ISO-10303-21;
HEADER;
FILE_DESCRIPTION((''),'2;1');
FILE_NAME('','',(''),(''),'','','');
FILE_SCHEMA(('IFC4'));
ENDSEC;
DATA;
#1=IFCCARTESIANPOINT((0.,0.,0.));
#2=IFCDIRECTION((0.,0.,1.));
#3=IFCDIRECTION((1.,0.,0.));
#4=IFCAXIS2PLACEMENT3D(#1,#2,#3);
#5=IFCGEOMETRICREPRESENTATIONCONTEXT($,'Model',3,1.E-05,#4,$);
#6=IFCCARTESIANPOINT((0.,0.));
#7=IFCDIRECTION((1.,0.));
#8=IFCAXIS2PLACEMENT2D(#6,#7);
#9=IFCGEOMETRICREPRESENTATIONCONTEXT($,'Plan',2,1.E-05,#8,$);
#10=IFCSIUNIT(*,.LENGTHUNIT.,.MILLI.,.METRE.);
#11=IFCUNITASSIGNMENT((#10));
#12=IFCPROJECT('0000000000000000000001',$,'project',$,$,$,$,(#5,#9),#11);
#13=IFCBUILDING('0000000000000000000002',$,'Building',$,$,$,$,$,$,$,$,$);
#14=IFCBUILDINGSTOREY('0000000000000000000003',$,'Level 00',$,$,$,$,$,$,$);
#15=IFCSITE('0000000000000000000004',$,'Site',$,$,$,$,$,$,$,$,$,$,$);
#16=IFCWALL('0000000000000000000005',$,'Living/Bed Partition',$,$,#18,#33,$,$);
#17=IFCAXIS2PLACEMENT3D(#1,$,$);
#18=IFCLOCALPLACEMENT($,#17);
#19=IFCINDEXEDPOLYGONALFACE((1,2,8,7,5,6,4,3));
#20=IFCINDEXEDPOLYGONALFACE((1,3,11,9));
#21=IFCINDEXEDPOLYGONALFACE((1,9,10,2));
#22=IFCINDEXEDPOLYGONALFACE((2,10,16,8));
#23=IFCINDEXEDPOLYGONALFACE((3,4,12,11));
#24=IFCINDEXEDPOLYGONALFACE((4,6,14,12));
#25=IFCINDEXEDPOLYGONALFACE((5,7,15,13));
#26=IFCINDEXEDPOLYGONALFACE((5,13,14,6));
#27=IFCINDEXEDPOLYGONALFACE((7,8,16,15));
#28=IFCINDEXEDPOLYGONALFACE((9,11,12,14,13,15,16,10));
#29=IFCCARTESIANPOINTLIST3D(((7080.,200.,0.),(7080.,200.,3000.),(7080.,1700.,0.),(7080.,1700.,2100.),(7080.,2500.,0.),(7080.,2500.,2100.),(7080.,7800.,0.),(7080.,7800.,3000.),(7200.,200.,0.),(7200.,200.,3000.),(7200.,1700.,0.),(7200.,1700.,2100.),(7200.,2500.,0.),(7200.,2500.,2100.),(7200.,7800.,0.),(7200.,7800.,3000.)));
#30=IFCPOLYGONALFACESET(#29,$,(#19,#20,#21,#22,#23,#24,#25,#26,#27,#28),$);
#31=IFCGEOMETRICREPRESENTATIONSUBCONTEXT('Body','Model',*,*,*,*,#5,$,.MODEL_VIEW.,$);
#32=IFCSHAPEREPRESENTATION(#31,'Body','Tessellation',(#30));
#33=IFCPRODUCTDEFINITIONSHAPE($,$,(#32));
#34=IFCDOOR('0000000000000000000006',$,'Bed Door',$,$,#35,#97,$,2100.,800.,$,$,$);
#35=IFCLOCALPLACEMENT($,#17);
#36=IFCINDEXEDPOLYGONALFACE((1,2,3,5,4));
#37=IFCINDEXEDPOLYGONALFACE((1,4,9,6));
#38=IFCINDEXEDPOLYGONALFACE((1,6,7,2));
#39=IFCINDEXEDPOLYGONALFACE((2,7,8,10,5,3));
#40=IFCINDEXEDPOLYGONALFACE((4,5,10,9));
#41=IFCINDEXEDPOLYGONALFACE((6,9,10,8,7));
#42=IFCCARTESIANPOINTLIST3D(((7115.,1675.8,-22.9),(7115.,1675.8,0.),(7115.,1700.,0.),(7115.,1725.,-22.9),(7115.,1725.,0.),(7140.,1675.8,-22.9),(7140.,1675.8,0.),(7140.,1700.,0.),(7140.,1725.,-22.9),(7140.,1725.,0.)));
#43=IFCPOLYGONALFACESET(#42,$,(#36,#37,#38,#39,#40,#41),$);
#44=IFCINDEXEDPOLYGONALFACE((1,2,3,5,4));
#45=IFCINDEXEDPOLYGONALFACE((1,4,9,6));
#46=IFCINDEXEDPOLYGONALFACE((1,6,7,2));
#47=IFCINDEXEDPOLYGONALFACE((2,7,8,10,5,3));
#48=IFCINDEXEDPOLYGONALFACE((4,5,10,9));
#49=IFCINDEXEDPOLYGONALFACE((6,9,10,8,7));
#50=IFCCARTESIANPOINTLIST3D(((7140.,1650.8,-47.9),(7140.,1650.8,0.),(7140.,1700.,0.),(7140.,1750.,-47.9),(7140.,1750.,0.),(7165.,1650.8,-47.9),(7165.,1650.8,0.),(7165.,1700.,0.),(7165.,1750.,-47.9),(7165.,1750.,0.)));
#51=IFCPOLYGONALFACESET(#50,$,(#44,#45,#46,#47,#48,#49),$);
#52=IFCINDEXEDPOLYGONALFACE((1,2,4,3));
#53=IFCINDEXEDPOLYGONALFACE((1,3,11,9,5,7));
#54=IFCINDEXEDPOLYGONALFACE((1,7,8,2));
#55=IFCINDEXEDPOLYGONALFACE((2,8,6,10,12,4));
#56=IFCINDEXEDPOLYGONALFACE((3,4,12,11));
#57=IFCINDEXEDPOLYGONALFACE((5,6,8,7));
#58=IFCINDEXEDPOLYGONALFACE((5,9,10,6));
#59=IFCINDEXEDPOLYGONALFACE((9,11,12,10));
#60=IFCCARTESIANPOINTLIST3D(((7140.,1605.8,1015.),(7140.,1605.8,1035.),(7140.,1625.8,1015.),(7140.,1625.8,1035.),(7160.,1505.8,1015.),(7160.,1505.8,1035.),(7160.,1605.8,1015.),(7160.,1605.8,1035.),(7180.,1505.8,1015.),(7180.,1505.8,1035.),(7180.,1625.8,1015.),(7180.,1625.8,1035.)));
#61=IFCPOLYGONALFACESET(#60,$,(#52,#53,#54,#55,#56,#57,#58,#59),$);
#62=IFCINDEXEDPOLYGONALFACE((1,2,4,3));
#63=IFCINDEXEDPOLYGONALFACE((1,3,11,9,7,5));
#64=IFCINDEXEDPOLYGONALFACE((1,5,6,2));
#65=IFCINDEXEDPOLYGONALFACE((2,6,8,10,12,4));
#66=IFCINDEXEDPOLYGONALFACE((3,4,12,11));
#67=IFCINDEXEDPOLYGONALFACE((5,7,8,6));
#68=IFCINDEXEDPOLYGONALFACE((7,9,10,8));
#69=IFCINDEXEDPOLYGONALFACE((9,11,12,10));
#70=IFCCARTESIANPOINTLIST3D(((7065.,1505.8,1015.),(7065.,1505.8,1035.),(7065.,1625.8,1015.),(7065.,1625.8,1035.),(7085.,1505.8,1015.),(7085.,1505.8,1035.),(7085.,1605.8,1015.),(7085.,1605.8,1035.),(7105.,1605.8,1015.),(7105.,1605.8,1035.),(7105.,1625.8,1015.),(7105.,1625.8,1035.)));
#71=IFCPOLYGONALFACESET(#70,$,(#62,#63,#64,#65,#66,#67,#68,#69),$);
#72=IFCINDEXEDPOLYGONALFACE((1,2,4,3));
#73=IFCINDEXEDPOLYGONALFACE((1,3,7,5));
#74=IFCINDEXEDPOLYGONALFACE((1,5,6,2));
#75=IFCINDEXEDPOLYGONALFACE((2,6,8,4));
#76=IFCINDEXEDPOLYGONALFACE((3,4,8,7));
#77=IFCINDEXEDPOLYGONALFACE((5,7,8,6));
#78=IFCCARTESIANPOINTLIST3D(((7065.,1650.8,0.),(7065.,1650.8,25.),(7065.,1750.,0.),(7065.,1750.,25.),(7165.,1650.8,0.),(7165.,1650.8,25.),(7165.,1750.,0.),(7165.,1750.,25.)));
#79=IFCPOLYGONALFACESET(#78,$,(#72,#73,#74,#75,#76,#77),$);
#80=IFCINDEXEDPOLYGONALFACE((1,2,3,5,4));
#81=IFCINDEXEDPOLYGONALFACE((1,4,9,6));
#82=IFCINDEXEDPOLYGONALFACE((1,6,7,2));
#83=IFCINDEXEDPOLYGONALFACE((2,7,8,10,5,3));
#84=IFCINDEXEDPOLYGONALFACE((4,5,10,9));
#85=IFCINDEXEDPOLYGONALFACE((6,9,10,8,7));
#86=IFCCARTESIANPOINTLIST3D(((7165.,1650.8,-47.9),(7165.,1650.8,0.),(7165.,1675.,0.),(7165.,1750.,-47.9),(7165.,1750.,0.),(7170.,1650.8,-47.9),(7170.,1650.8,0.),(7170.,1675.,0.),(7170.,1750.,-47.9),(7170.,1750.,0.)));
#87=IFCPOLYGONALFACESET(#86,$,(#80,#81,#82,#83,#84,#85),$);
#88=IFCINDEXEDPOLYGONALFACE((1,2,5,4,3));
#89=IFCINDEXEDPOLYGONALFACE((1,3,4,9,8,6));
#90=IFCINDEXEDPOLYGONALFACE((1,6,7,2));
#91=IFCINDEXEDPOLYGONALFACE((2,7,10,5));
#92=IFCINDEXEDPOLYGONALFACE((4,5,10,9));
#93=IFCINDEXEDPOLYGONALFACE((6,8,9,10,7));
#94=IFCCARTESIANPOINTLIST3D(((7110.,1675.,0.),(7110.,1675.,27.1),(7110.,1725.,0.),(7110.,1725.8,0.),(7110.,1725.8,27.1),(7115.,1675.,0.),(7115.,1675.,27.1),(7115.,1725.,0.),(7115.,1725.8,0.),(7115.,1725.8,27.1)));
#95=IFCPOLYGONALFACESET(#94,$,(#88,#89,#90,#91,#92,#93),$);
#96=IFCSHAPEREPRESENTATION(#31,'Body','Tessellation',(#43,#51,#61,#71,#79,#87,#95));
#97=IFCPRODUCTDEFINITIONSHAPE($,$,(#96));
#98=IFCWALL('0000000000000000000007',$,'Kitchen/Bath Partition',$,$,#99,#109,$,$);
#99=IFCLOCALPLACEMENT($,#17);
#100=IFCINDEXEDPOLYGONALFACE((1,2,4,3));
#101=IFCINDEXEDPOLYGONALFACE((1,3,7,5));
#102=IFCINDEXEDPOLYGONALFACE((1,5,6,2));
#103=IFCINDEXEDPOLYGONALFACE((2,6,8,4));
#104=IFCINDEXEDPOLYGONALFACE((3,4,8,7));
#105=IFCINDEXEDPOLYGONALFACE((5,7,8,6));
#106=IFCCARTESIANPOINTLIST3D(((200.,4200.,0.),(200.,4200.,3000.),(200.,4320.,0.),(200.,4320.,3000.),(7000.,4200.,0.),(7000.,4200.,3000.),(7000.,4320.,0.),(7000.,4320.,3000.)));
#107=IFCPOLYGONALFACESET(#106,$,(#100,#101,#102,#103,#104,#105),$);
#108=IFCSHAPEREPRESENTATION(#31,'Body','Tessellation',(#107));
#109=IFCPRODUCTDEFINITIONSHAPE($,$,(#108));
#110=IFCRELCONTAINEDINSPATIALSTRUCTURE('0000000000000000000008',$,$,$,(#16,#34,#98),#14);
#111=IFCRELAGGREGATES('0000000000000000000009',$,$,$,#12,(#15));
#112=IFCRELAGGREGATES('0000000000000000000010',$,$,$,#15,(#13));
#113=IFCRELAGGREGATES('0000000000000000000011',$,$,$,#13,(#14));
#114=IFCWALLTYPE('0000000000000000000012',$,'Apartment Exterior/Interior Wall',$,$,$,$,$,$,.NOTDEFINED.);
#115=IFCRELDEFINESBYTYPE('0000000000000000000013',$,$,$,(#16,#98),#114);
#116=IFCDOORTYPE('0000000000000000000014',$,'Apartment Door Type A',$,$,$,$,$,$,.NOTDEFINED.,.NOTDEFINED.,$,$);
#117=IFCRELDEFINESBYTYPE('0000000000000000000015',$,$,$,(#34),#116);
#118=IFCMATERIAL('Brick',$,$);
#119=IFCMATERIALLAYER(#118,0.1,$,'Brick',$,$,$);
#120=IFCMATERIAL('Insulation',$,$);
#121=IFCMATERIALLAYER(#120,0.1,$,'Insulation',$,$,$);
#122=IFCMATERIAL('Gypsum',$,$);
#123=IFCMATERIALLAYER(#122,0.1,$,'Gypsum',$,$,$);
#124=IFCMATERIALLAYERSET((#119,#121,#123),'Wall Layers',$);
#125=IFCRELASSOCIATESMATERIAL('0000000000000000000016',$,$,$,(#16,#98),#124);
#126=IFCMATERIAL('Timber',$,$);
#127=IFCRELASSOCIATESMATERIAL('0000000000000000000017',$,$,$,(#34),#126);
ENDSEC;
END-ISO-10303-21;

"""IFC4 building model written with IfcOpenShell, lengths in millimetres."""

from ifc_helpers import new_model, si_unit, frame, origin_with_axes, origin_2d_with_axis, place, context, subcontext, project, spatial, line, indexed_curve, outline, extrude, material, layer, layer_set, layer_usage, type_object, element, fill, save


model = new_model("IFC4")

# Units and contexts
model_context = context("Model", 3, precision=1e-05, world=origin_with_axes())
plan_context = context("Plan", 2, precision=1e-05, world=origin_2d_with_axis())
body_context = subcontext(model_context, "Body", "Model", "MODEL_VIEW")
ifc_project = project(units=[si_unit("LENGTHUNIT", "METRE", prefix="MILLI")], contexts=[model_context, plan_context])

# Site, building, storey
site = spatial("IfcSite", under=ifc_project, Name="Site")
building = spatial("IfcBuilding", under=site, Name="Building")
storey = spatial("IfcBuildingStorey", under=building, Name="Level 00")

# Shared definitions
ifc_material_1 = material(Name="Brick")
ifc_layer_1 = layer(ifc_material_1, 0.1, Name="Brick")
ifc_material_2 = material(Name="Insulation")
ifc_layer_2 = layer(ifc_material_2, 0.1, Name="Insulation")
ifc_material_3 = material(Name="Gypsum")
ifc_layer_3 = layer(ifc_material_3, 0.1, Name="Gypsum")
ifc_layer_set = layer_set([ifc_layer_1, ifc_layer_2, ifc_layer_3], Name="Wall Layers")
ifc_layer_usage = layer_usage(ifc_layer_set, "AXIS2", "POSITIVE", 0.0)
wall_type = type_object("IfcWallType", Name="Apartment Exterior/Interior Wall", PredefinedType="NOTDEFINED")
ifc_material_4 = material(Name="Timber")
door_type = type_object("IfcDoorType", Name="Apartment Door Type A", OperationType="NOTDEFINED", PredefinedType="NOTDEFINED")

# Wall, opening, door
wall_1_placement = place(None, frame((7200.0, 200.0, 0.0), z_axis=(0.0, 0.0, 1.0), x_axis=(0.0, 1.0, 0.0)))
wall_1 = element("IfcWall", 1, at=wall_1_placement, inside=storey, type_object=wall_type, material=ifc_layer_usage, Name="Living/Bed Partition", context=body_context, shape_type="SweptSolid", body=[
    extrude(outline(indexed_curve([(0.0, 0.0), (0.0, 120.0), (7600.0, 120.0), (7600.0, 0.0), (0.0, 0.0)], self_intersect=False)), origin_with_axes(), (0.0, 0.0, 1.0), 3000.0),
])
opening_1_placement = place(wall_1_placement, frame((1500.0, -12.0, 0.0), z_axis=(0.0, 0.0, 1.0), x_axis=(1.0, 0.0, 0.0)))
opening_1 = element("IfcOpeningElement", 2, at=opening_1_placement, cuts=wall_1, context=body_context, shape_type="SweptSolid", body=[
    extrude(outline(indexed_curve([(0.0, 0.0), (0.0, 144.0), (800.0, 144.0), (800.0, 0.0), (0.0, 0.0)], self_intersect=False)), origin_with_axes(), (0.0, 0.0, 1.0), 2100.0),
])
door_1_placement = place(opening_1_placement, frame((0.0, 47.0, 0.0), z_axis=(0.0, 0.0, 1.0), x_axis=(1.0, 0.0, 0.0)))
door_1 = element("IfcDoor", 3, at=door_1_placement, inside=storey, type_object=door_type, material=ifc_material_4, Name="Bed Door", OverallHeight=2100.0, OverallWidth=800.0, context=body_context, shape_type="SweptSolid", body=[
    extrude(outline(indexed_curve([(0.0, 0.0), (0.0, 2.1), (0.8, 2.1), (0.8, 0.0), (-24.2, 0.0), (-24.2, -22.9), (25.0, -22.9), (25.0, 0.0)], segments=[line(1, 2, 3, 4, 5, 6, 7, 8, 1)])), frame((0.0, 25.0, 0.0), z_axis=(0.0, -1.0, 0.0), x_axis=(1.0, 0.0, 0.0)), (0.0, 0.0, -1.0), 25.0),
    extrude(outline(indexed_curve([(0.0, 0.0), (0.0, 2.1), (0.8, 2.1), (0.8, 0.0), (-49.2, 0.0), (-49.2, -47.9), (50.0, -47.9), (50.0, 0.0)], segments=[line(1, 2, 3, 4, 5, 6, 7, 8, 1)])), frame((0.0, 0.0, 0.0), z_axis=(0.0, -1.0, 0.0), x_axis=(1.0, 0.0, 0.0)), (0.0, 0.0, -1.0), 25.0),
    extrude(outline(indexed_curve([(0.0, 0.0), (-49.2, 0.0), (-49.2, 35.0), (0.0, 35.0)], segments=[line(1, 2, 3, 4, 1)])), frame((25.0, 25.0, 25.0), z_axis=(0.0, 0.0, 1.0), x_axis=(1.0, 0.0, 0.0)), (0.0, 0.0, 1.0), -47.9),
    extrude(outline(indexed_curve([(0.0, 0.0), (0.0, -40.0), (-120.0, -40.0), (-120.0, -20.0), (-20.0, -20.0), (-20.0, 0.0)], segments=[line(1, 2, 3, 4, 5, 6, 1)])), frame((-74.2, 25.0, 1015.0), z_axis=(0.0, 0.0, 1.0), x_axis=(1.0, 0.0, 0.0)), (0.0, 0.0, 1.0), 20.0),
    extrude(outline(indexed_curve([(0.0, 0.0), (0.0, 40.0), (-120.0, 40.0), (-120.0, 20.0), (-20.0, 20.0), (-20.0, 0.0)], segments=[line(1, 2, 3, 4, 5, 6, 1)])), frame((-74.2, 60.0, 1015.0), z_axis=(0.0, 0.0, 1.0), x_axis=(1.0, 0.0, 0.0)), (0.0, 0.0, 1.0), 20.0),
    extrude(outline(indexed_curve([(0.0, 0.0), (-99.2, 0.0), (-99.2, 100.0), (0.0, 100.0)], segments=[line(1, 2, 3, 4, 1)])), frame((50.0, 0.0, 0.0), z_axis=(0.0, 0.0, 1.0), x_axis=(1.0, 0.0, 0.0)), (0.0, 0.0, 1.0), 25.0),
    extrude(outline(indexed_curve([(0.0, 0.0), (0.0, 27.1), (50.8, 27.1), (50.8, 0.0), (-24.2, 0.0), (-24.2, -47.9), (75.0, -47.9), (75.0, 0.0)], segments=[line(1, 2, 3, 4, 5, 6, 7, 8, 1)])), frame((-25.0, -5.0, 0.0), z_axis=(0.0, -1.0, 0.0), x_axis=(1.0, 0.0, 0.0)), (0.0, 0.0, -1.0), 5.0),
    extrude(outline(indexed_curve([(0.0, 0.0), (0.0, 27.1), (50.8, 27.1), (50.8, 0.0), (0.8, 0.0), (0.8, -22.9), (50.0, -22.9), (50.0, 0.0)], segments=[line(1, 2, 3, 4, 5, 6, 7, 8, 1)])), frame((-25.0, 50.0, 0.0), z_axis=(0.0, -1.0, 0.0), x_axis=(1.0, 0.0, 0.0)), (0.0, 0.0, -1.0), 5.0),
])
fill(opening_1, door_1)

# Wall
wall_2_placement = place(None, frame((200.0, 4200.0, 0.0), z_axis=(0.0, 0.0, 1.0), x_axis=(1.0, 0.0, 0.0)))
element("IfcWall", 4, at=wall_2_placement, inside=storey, type_object=wall_type, material=ifc_layer_usage, Name="Kitchen/Bath Partition", context=body_context, shape_type="SweptSolid", body=[
    extrude(outline(indexed_curve([(0.0, 0.0), (0.0, 120.0), (6800.0, 120.0), (6800.0, 0.0), (0.0, 0.0)], self_intersect=False)), origin_with_axes(), (0.0, 0.0, 1.0), 3000.0),
])

save(model, "model.ifc")
